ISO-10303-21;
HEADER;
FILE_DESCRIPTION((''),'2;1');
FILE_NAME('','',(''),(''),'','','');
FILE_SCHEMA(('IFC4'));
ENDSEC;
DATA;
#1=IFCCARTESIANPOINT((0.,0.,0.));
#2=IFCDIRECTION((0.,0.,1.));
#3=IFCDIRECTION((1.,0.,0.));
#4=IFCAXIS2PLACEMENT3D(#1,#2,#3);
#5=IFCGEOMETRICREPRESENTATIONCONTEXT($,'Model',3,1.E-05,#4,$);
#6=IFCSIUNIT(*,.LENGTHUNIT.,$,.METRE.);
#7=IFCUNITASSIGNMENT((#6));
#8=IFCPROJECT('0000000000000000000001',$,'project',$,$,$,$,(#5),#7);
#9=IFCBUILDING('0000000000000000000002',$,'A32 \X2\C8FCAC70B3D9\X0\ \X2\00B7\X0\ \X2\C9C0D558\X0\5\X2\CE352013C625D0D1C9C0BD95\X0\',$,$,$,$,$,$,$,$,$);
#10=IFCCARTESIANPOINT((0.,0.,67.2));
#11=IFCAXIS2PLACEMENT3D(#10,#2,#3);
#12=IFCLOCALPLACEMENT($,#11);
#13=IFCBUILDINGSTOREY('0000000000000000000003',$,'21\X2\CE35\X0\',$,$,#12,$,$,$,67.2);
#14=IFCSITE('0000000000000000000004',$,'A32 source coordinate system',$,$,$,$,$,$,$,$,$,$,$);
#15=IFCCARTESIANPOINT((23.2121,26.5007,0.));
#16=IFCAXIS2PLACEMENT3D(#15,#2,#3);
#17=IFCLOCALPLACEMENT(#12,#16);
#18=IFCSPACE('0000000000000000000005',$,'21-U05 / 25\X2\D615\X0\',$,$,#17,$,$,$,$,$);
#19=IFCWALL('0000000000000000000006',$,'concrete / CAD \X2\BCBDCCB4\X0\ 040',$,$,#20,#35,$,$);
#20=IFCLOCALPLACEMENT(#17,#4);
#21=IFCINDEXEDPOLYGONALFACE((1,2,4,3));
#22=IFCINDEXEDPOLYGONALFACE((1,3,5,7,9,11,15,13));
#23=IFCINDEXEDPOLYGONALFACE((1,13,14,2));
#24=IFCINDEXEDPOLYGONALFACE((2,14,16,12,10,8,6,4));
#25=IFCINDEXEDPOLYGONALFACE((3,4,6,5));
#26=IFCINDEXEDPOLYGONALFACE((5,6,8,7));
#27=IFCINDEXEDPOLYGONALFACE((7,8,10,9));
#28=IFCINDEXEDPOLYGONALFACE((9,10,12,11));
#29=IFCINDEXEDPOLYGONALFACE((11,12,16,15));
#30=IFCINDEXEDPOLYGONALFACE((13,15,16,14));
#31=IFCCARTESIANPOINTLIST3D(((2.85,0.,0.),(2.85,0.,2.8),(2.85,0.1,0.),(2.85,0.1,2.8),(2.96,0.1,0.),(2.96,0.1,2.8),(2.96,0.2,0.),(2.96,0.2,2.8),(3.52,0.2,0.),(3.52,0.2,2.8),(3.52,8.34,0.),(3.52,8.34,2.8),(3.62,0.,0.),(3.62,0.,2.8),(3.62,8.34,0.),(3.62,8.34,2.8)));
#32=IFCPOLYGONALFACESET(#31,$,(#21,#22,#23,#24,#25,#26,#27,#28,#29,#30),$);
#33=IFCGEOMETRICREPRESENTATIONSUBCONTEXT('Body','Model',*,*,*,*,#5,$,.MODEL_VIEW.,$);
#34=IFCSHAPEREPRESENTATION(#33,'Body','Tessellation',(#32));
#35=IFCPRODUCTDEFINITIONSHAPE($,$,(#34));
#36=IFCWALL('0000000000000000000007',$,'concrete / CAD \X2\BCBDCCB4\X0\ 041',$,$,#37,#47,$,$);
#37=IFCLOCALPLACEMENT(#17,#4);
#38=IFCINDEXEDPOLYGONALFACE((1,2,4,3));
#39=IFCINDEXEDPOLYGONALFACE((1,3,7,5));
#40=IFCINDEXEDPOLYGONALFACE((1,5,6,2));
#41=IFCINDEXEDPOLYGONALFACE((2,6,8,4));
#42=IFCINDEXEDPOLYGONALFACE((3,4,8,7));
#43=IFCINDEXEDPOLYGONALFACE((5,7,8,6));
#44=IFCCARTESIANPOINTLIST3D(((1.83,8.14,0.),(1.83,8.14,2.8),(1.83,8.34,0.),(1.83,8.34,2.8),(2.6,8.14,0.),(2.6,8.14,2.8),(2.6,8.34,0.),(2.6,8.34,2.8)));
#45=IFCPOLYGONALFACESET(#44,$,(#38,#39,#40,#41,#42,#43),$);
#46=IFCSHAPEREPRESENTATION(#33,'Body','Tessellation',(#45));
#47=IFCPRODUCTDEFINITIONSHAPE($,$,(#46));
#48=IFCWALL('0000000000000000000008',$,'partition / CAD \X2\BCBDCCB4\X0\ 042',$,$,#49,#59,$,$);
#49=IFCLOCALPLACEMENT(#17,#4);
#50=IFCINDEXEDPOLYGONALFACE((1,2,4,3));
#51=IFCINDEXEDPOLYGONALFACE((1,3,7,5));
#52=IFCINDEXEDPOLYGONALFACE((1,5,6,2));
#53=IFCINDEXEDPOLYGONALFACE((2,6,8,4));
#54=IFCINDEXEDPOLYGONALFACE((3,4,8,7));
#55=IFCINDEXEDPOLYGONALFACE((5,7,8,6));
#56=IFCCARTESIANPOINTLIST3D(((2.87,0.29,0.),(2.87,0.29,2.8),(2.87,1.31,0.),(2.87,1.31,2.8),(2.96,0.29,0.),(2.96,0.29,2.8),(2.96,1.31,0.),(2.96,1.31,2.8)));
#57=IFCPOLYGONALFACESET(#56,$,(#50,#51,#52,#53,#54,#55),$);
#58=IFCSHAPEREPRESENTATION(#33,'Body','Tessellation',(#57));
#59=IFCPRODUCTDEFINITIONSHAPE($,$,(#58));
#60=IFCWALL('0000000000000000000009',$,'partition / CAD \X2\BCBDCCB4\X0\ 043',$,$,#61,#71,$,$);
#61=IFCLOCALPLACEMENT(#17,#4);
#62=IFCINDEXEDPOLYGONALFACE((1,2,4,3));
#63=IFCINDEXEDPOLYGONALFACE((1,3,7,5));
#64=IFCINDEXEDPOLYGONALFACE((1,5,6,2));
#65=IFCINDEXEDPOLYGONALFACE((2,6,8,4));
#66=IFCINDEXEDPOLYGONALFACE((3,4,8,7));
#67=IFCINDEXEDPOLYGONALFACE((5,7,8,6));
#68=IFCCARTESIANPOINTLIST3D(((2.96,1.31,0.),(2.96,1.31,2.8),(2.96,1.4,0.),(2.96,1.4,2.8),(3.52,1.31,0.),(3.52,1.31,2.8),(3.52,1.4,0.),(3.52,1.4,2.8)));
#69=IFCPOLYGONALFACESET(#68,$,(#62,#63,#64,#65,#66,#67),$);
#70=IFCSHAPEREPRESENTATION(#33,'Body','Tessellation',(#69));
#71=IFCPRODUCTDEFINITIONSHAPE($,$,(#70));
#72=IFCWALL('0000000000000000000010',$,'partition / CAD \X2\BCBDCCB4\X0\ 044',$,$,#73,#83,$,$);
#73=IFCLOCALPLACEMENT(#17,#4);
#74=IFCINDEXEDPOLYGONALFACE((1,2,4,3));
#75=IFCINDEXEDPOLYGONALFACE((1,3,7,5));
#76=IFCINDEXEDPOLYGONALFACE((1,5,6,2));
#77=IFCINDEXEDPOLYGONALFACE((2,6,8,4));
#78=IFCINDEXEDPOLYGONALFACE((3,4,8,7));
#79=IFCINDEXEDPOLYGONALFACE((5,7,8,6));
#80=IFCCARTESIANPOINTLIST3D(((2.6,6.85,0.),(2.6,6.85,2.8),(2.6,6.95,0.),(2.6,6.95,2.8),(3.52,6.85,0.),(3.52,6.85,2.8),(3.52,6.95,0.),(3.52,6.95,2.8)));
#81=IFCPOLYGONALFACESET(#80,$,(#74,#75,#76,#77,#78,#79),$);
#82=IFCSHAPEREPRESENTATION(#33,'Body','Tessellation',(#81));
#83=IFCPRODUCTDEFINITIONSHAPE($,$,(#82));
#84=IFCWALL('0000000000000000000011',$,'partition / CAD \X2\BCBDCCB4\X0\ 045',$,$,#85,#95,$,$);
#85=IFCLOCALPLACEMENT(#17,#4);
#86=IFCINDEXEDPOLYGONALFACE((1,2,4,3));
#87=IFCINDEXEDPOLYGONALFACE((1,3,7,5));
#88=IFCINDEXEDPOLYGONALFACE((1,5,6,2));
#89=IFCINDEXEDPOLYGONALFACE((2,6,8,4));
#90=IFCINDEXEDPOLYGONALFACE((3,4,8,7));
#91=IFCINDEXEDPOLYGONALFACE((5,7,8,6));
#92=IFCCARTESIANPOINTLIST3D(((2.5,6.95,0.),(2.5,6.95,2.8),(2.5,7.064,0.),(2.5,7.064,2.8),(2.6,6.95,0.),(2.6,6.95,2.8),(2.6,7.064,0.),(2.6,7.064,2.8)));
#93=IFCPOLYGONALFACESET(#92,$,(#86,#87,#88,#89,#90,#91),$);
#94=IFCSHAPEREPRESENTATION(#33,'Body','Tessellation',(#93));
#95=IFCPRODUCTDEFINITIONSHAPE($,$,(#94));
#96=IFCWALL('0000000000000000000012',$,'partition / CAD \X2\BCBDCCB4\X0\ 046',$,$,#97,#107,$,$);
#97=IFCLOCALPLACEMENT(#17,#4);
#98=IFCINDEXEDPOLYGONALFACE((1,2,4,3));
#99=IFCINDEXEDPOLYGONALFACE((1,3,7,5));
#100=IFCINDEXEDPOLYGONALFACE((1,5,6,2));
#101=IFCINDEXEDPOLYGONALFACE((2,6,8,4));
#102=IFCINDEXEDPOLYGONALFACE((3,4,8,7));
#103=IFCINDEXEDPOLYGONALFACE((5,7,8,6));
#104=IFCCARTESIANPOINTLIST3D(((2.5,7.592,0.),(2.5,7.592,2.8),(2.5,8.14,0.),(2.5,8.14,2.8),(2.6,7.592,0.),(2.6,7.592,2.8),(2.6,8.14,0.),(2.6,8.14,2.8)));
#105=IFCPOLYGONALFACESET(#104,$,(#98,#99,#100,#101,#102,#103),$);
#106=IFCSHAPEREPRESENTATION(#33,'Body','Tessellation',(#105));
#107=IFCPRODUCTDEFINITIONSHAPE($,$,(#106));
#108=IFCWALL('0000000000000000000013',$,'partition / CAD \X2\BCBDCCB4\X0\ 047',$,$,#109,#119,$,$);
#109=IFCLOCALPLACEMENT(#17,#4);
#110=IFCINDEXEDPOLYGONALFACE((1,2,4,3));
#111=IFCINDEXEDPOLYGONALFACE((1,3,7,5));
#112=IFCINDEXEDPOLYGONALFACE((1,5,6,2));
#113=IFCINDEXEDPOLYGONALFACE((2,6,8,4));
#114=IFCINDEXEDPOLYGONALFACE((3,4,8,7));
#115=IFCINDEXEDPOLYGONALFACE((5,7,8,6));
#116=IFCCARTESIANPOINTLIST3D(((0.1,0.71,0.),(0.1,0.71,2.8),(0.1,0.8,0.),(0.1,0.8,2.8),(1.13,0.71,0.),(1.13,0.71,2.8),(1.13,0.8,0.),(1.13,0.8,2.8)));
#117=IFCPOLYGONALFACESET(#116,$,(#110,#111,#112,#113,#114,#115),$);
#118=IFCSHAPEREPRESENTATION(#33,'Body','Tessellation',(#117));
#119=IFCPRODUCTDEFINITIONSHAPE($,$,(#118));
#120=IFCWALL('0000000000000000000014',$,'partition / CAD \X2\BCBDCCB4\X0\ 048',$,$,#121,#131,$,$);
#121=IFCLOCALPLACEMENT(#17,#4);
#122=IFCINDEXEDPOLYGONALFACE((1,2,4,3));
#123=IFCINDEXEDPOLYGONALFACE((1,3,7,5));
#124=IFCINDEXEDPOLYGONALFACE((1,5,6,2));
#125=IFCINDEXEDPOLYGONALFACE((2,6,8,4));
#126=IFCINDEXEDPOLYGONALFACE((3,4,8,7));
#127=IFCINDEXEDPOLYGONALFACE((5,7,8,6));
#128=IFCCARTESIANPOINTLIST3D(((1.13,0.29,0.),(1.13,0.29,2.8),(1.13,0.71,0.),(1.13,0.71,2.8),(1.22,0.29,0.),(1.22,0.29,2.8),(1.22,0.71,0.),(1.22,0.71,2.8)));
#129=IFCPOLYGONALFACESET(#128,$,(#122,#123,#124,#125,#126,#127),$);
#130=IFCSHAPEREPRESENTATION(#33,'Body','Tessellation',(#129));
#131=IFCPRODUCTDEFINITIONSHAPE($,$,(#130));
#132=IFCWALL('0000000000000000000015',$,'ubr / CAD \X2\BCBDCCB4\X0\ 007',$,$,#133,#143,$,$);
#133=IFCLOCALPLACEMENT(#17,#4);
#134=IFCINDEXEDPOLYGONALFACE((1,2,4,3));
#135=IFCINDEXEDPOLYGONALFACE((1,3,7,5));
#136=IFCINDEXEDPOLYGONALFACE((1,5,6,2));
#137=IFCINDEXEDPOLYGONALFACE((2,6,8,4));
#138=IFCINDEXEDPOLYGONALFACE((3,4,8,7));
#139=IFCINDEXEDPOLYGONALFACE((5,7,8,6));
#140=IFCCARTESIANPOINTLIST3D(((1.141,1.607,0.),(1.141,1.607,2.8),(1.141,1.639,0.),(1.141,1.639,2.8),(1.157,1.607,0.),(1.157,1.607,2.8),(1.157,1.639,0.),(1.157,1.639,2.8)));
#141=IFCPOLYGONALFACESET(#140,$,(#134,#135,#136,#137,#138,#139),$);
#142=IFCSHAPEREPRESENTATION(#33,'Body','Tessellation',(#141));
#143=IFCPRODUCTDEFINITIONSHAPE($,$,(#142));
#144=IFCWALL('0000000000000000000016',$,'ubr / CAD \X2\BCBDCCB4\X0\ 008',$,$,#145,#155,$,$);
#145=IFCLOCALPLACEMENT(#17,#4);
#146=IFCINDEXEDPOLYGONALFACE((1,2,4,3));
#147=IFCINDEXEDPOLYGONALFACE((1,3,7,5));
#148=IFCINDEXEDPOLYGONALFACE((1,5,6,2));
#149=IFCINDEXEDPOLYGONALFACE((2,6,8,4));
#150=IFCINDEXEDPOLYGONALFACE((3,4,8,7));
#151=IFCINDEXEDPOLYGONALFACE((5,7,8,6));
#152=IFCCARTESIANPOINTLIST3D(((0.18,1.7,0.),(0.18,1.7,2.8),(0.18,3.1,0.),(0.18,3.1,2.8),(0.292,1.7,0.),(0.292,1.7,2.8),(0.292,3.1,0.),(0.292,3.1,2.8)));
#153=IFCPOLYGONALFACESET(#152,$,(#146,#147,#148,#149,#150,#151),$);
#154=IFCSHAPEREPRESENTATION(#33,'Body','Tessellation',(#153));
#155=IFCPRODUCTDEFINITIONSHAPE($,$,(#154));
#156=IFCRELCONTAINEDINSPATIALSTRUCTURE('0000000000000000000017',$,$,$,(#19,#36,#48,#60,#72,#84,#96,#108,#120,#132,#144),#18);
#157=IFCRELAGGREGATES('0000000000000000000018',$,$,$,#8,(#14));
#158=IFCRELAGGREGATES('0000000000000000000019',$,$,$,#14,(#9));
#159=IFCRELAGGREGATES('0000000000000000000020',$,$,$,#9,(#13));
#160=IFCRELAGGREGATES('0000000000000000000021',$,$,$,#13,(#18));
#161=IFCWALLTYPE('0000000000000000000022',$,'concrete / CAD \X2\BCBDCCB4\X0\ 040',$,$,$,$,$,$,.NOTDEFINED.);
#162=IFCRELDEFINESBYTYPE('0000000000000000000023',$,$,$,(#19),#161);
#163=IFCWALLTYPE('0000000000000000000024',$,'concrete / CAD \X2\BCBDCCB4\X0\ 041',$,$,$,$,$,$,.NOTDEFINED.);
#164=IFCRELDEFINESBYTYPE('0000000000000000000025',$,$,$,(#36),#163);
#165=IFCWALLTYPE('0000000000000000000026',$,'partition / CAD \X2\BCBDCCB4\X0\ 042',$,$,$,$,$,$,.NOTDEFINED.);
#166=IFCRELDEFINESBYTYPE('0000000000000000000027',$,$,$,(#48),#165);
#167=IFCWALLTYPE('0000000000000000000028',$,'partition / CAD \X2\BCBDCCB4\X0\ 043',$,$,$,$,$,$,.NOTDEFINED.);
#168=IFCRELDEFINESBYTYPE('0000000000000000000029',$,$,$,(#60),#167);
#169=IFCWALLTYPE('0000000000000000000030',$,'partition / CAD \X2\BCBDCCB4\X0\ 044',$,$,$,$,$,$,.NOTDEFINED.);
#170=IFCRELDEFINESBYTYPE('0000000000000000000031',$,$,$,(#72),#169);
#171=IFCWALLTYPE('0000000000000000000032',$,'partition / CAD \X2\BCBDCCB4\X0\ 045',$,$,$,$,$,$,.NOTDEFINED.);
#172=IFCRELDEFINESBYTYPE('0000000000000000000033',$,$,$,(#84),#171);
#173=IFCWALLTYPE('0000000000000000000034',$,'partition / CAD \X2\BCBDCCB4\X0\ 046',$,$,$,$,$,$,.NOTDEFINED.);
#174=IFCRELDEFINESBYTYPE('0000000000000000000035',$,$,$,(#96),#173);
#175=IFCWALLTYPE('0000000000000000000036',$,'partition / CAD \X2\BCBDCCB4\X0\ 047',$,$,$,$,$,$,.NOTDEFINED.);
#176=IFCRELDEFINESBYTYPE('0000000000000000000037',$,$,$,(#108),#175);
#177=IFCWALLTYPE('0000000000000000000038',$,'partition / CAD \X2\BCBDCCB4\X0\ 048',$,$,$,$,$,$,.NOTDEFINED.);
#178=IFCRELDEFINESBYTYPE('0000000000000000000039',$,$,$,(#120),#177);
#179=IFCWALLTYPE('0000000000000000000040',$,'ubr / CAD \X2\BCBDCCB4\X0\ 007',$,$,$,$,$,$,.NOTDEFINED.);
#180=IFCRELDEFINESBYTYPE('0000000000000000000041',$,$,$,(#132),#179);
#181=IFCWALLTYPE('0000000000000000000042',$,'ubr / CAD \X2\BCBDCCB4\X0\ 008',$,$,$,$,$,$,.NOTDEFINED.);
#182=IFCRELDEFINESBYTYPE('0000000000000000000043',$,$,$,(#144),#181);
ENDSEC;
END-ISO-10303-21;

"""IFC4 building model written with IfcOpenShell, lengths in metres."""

from ifc_helpers import new_model, si_unit, frame, origin, origin_with_axes, place, context, subcontext, project, spatial, polyline, outline, extrude, source, transform, mapped, type_object, type_shapes, element, save


model = new_model("IFC4")

# Units and contexts
model_context = context("Model", 3, precision=1e-05, world=origin_with_axes())
body_context = subcontext(model_context, "Body", "Model", "MODEL_VIEW")
ifc_project = project(units=[si_unit("LENGTHUNIT", "METRE")], contexts=[model_context])

# Site, building, storey, space
site = spatial("IfcSite", under=ifc_project, Name="A32 source coordinate system")
building = spatial("IfcBuilding", under=site, Name="A32 주거동 · 지하5층–옥탑지붕")
storey_placement = place(None, frame((0.0, 0.0, 67.2), z_axis=(0.0, 0.0, 1.0), x_axis=(1.0, 0.0, 0.0)))
storey = spatial("IfcBuildingStorey", under=building, at=storey_placement, Name="21층", Elevation=67.2)
space_1_placement = place(storey_placement, frame((23.2121, 26.5007, 0.0), z_axis=(0.0, 0.0, 1.0), x_axis=(1.0, 0.0, 0.0)))
space_1 = spatial("IfcSpace", under=storey, at=space_1_placement, Name="21-U05 / 25형")

# Walls
wall_type_1 = type_object("IfcWallType", Name="concrete / CAD 벽체 040", PredefinedType="NOTDEFINED")
shared_shape_1 = source(origin(), body_context, "Body", "SweptSolid", [
    extrude(outline(polyline([(3.62, 8.34), (3.62, 0.0), (2.85, 0.0), (2.85, 0.1), (2.96, 0.1), (2.96, 0.2), (3.52, 0.2), (3.52, 8.34), (3.62, 8.34)])), origin(), (0.0, 0.0, 1.0), 2.8),
])
type_shapes(wall_type_1, [shared_shape_1])
wall_1_placement = place(space_1_placement, origin_with_axes())
element("IfcWall", 1, at=wall_1_placement, inside=space_1, type_object=wall_type_1, Name="concrete / CAD 벽체 040", context=body_context, shape_type="MappedRepresentation", body=[
    mapped(shared_shape_1, transform((0.0, 0.0, 0.0), scale=1.0)),
])
wall_type_2 = type_object("IfcWallType", Name="concrete / CAD 벽체 041", PredefinedType="NOTDEFINED")
shared_shape_2 = source(origin(), body_context, "Body", "SweptSolid", [
    extrude(outline(polyline([(2.6, 8.14), (1.83, 8.14), (1.83, 8.34), (2.6, 8.34), (2.6, 8.14)])), origin(), (0.0, 0.0, 1.0), 2.8),
])
type_shapes(wall_type_2, [shared_shape_2])
wall_2_placement = place(space_1_placement, origin_with_axes())
element("IfcWall", 2, at=wall_2_placement, inside=space_1, type_object=wall_type_2, Name="concrete / CAD 벽체 041", context=body_context, shape_type="MappedRepresentation", body=[
    mapped(shared_shape_2, transform((0.0, 0.0, 0.0), scale=1.0)),
])
wall_type_3 = type_object("IfcWallType", Name="partition / CAD 벽체 042", PredefinedType="NOTDEFINED")
shared_shape_3 = source(origin(), body_context, "Body", "SweptSolid", [
    extrude(outline(polyline([(2.87, 1.31), (2.96, 1.31), (2.96, 0.29), (2.87, 0.29), (2.87, 1.31)])), origin(), (0.0, 0.0, 1.0), 2.8),
])
type_shapes(wall_type_3, [shared_shape_3])
wall_3_placement = place(space_1_placement, origin_with_axes())
element("IfcWall", 3, at=wall_3_placement, inside=space_1, type_object=wall_type_3, Name="partition / CAD 벽체 042", context=body_context, shape_type="MappedRepresentation", body=[
    mapped(shared_shape_3, transform((0.0, 0.0, 0.0), scale=1.0)),
])
wall_type_4 = type_object("IfcWallType", Name="partition / CAD 벽체 043", PredefinedType="NOTDEFINED")
shared_shape_4 = source(origin(), body_context, "Body", "SweptSolid", [
    extrude(outline(polyline([(3.52, 1.4), (3.52, 1.31), (2.96, 1.31), (2.96, 1.4), (3.52, 1.4)])), origin(), (0.0, 0.0, 1.0), 2.8),
])
type_shapes(wall_type_4, [shared_shape_4])
wall_4_placement = place(space_1_placement, origin_with_axes())
element("IfcWall", 4, at=wall_4_placement, inside=space_1, type_object=wall_type_4, Name="partition / CAD 벽체 043", context=body_context, shape_type="MappedRepresentation", body=[
    mapped(shared_shape_4, transform((0.0, 0.0, 0.0), scale=1.0)),
])
wall_type_5 = type_object("IfcWallType", Name="partition / CAD 벽체 044", PredefinedType="NOTDEFINED")
shared_shape_5 = source(origin(), body_context, "Body", "SweptSolid", [
    extrude(outline(polyline([(3.52, 6.95), (3.52, 6.85), (2.6, 6.85), (2.6, 6.95), (3.52, 6.95)])), origin(), (0.0, 0.0, 1.0), 2.8),
])
type_shapes(wall_type_5, [shared_shape_5])
wall_5_placement = place(space_1_placement, origin_with_axes())
element("IfcWall", 5, at=wall_5_placement, inside=space_1, type_object=wall_type_5, Name="partition / CAD 벽체 044", context=body_context, shape_type="MappedRepresentation", body=[
    mapped(shared_shape_5, transform((0.0, 0.0, 0.0), scale=1.0)),
])
wall_type_6 = type_object("IfcWallType", Name="partition / CAD 벽체 045", PredefinedType="NOTDEFINED")
shared_shape_6 = source(origin(), body_context, "Body", "SweptSolid", [
    extrude(outline(polyline([(2.5, 7.064), (2.6, 7.064), (2.6, 6.95), (2.5, 6.95), (2.5, 7.064)])), origin(), (0.0, 0.0, 1.0), 2.8),
])
type_shapes(wall_type_6, [shared_shape_6])
wall_6_placement = place(space_1_placement, origin_with_axes())
element("IfcWall", 6, at=wall_6_placement, inside=space_1, type_object=wall_type_6, Name="partition / CAD 벽체 045", context=body_context, shape_type="MappedRepresentation", body=[
    mapped(shared_shape_6, transform((0.0, 0.0, 0.0), scale=1.0)),
])
wall_type_7 = type_object("IfcWallType", Name="partition / CAD 벽체 046", PredefinedType="NOTDEFINED")
shared_shape_7 = source(origin(), body_context, "Body", "SweptSolid", [
    extrude(outline(polyline([(2.6, 7.592), (2.5, 7.592), (2.5, 8.14), (2.6, 8.14), (2.6, 7.592)])), origin(), (0.0, 0.0, 1.0), 2.8),
])
type_shapes(wall_type_7, [shared_shape_7])
wall_7_placement = place(space_1_placement, origin_with_axes())
element("IfcWall", 7, at=wall_7_placement, inside=space_1, type_object=wall_type_7, Name="partition / CAD 벽체 046", context=body_context, shape_type="MappedRepresentation", body=[
    mapped(shared_shape_7, transform((0.0, 0.0, 0.0), scale=1.0)),
])
wall_type_8 = type_object("IfcWallType", Name="partition / CAD 벽체 047", PredefinedType="NOTDEFINED")
shared_shape_8 = source(origin(), body_context, "Body", "SweptSolid", [
    extrude(outline(polyline([(1.13, 0.71), (0.1, 0.71), (0.1, 0.8), (1.13, 0.8), (1.13, 0.71)])), origin(), (0.0, 0.0, 1.0), 2.8),
])
type_shapes(wall_type_8, [shared_shape_8])
wall_8_placement = place(space_1_placement, origin_with_axes())
element("IfcWall", 8, at=wall_8_placement, inside=space_1, type_object=wall_type_8, Name="partition / CAD 벽체 047", context=body_context, shape_type="MappedRepresentation", body=[
    mapped(shared_shape_8, transform((0.0, 0.0, 0.0), scale=1.0)),
])
wall_type_9 = type_object("IfcWallType", Name="partition / CAD 벽체 048", PredefinedType="NOTDEFINED")
shared_shape_9 = source(origin(), body_context, "Body", "SweptSolid", [
    extrude(outline(polyline([(1.22, 0.29), (1.13, 0.29), (1.13, 0.71), (1.22, 0.71), (1.22, 0.29)])), origin(), (0.0, 0.0, 1.0), 2.8),
])
type_shapes(wall_type_9, [shared_shape_9])
wall_9_placement = place(space_1_placement, origin_with_axes())
element("IfcWall", 9, at=wall_9_placement, inside=space_1, type_object=wall_type_9, Name="partition / CAD 벽체 048", context=body_context, shape_type="MappedRepresentation", body=[
    mapped(shared_shape_9, transform((0.0, 0.0, 0.0), scale=1.0)),
])
wall_type_10 = type_object("IfcWallType", Name="ubr / CAD 벽체 007", PredefinedType="NOTDEFINED")
shared_shape_10 = source(origin(), body_context, "Body", "SweptSolid", [
    extrude(outline(polyline([(1.157, 1.607), (1.141, 1.607), (1.141, 1.639), (1.157, 1.639), (1.157, 1.607)])), origin(), (0.0, 0.0, 1.0), 2.8),
])
type_shapes(wall_type_10, [shared_shape_10])
wall_10_placement = place(space_1_placement, origin_with_axes())
element("IfcWall", 10, at=wall_10_placement, inside=space_1, type_object=wall_type_10, Name="ubr / CAD 벽체 007", context=body_context, shape_type="MappedRepresentation", body=[
    mapped(shared_shape_10, transform((0.0, 0.0, 0.0), scale=1.0)),
])
wall_type_11 = type_object("IfcWallType", Name="ubr / CAD 벽체 008", PredefinedType="NOTDEFINED")
shared_shape_11 = source(origin(), body_context, "Body", "SweptSolid", [
    extrude(outline(polyline([(0.292, 1.7), (0.18, 1.7), (0.18, 3.1), (0.292, 3.1), (0.292, 1.7)])), origin(), (0.0, 0.0, 1.0), 2.8),
])
type_shapes(wall_type_11, [shared_shape_11])
wall_11_placement = place(space_1_placement, origin_with_axes())
element("IfcWall", 11, at=wall_11_placement, inside=space_1, type_object=wall_type_11, Name="ubr / CAD 벽체 008", context=body_context, shape_type="MappedRepresentation", body=[
    mapped(shared_shape_11, transform((0.0, 0.0, 0.0), scale=1.0)),
])

save(model, "model.ifc")
